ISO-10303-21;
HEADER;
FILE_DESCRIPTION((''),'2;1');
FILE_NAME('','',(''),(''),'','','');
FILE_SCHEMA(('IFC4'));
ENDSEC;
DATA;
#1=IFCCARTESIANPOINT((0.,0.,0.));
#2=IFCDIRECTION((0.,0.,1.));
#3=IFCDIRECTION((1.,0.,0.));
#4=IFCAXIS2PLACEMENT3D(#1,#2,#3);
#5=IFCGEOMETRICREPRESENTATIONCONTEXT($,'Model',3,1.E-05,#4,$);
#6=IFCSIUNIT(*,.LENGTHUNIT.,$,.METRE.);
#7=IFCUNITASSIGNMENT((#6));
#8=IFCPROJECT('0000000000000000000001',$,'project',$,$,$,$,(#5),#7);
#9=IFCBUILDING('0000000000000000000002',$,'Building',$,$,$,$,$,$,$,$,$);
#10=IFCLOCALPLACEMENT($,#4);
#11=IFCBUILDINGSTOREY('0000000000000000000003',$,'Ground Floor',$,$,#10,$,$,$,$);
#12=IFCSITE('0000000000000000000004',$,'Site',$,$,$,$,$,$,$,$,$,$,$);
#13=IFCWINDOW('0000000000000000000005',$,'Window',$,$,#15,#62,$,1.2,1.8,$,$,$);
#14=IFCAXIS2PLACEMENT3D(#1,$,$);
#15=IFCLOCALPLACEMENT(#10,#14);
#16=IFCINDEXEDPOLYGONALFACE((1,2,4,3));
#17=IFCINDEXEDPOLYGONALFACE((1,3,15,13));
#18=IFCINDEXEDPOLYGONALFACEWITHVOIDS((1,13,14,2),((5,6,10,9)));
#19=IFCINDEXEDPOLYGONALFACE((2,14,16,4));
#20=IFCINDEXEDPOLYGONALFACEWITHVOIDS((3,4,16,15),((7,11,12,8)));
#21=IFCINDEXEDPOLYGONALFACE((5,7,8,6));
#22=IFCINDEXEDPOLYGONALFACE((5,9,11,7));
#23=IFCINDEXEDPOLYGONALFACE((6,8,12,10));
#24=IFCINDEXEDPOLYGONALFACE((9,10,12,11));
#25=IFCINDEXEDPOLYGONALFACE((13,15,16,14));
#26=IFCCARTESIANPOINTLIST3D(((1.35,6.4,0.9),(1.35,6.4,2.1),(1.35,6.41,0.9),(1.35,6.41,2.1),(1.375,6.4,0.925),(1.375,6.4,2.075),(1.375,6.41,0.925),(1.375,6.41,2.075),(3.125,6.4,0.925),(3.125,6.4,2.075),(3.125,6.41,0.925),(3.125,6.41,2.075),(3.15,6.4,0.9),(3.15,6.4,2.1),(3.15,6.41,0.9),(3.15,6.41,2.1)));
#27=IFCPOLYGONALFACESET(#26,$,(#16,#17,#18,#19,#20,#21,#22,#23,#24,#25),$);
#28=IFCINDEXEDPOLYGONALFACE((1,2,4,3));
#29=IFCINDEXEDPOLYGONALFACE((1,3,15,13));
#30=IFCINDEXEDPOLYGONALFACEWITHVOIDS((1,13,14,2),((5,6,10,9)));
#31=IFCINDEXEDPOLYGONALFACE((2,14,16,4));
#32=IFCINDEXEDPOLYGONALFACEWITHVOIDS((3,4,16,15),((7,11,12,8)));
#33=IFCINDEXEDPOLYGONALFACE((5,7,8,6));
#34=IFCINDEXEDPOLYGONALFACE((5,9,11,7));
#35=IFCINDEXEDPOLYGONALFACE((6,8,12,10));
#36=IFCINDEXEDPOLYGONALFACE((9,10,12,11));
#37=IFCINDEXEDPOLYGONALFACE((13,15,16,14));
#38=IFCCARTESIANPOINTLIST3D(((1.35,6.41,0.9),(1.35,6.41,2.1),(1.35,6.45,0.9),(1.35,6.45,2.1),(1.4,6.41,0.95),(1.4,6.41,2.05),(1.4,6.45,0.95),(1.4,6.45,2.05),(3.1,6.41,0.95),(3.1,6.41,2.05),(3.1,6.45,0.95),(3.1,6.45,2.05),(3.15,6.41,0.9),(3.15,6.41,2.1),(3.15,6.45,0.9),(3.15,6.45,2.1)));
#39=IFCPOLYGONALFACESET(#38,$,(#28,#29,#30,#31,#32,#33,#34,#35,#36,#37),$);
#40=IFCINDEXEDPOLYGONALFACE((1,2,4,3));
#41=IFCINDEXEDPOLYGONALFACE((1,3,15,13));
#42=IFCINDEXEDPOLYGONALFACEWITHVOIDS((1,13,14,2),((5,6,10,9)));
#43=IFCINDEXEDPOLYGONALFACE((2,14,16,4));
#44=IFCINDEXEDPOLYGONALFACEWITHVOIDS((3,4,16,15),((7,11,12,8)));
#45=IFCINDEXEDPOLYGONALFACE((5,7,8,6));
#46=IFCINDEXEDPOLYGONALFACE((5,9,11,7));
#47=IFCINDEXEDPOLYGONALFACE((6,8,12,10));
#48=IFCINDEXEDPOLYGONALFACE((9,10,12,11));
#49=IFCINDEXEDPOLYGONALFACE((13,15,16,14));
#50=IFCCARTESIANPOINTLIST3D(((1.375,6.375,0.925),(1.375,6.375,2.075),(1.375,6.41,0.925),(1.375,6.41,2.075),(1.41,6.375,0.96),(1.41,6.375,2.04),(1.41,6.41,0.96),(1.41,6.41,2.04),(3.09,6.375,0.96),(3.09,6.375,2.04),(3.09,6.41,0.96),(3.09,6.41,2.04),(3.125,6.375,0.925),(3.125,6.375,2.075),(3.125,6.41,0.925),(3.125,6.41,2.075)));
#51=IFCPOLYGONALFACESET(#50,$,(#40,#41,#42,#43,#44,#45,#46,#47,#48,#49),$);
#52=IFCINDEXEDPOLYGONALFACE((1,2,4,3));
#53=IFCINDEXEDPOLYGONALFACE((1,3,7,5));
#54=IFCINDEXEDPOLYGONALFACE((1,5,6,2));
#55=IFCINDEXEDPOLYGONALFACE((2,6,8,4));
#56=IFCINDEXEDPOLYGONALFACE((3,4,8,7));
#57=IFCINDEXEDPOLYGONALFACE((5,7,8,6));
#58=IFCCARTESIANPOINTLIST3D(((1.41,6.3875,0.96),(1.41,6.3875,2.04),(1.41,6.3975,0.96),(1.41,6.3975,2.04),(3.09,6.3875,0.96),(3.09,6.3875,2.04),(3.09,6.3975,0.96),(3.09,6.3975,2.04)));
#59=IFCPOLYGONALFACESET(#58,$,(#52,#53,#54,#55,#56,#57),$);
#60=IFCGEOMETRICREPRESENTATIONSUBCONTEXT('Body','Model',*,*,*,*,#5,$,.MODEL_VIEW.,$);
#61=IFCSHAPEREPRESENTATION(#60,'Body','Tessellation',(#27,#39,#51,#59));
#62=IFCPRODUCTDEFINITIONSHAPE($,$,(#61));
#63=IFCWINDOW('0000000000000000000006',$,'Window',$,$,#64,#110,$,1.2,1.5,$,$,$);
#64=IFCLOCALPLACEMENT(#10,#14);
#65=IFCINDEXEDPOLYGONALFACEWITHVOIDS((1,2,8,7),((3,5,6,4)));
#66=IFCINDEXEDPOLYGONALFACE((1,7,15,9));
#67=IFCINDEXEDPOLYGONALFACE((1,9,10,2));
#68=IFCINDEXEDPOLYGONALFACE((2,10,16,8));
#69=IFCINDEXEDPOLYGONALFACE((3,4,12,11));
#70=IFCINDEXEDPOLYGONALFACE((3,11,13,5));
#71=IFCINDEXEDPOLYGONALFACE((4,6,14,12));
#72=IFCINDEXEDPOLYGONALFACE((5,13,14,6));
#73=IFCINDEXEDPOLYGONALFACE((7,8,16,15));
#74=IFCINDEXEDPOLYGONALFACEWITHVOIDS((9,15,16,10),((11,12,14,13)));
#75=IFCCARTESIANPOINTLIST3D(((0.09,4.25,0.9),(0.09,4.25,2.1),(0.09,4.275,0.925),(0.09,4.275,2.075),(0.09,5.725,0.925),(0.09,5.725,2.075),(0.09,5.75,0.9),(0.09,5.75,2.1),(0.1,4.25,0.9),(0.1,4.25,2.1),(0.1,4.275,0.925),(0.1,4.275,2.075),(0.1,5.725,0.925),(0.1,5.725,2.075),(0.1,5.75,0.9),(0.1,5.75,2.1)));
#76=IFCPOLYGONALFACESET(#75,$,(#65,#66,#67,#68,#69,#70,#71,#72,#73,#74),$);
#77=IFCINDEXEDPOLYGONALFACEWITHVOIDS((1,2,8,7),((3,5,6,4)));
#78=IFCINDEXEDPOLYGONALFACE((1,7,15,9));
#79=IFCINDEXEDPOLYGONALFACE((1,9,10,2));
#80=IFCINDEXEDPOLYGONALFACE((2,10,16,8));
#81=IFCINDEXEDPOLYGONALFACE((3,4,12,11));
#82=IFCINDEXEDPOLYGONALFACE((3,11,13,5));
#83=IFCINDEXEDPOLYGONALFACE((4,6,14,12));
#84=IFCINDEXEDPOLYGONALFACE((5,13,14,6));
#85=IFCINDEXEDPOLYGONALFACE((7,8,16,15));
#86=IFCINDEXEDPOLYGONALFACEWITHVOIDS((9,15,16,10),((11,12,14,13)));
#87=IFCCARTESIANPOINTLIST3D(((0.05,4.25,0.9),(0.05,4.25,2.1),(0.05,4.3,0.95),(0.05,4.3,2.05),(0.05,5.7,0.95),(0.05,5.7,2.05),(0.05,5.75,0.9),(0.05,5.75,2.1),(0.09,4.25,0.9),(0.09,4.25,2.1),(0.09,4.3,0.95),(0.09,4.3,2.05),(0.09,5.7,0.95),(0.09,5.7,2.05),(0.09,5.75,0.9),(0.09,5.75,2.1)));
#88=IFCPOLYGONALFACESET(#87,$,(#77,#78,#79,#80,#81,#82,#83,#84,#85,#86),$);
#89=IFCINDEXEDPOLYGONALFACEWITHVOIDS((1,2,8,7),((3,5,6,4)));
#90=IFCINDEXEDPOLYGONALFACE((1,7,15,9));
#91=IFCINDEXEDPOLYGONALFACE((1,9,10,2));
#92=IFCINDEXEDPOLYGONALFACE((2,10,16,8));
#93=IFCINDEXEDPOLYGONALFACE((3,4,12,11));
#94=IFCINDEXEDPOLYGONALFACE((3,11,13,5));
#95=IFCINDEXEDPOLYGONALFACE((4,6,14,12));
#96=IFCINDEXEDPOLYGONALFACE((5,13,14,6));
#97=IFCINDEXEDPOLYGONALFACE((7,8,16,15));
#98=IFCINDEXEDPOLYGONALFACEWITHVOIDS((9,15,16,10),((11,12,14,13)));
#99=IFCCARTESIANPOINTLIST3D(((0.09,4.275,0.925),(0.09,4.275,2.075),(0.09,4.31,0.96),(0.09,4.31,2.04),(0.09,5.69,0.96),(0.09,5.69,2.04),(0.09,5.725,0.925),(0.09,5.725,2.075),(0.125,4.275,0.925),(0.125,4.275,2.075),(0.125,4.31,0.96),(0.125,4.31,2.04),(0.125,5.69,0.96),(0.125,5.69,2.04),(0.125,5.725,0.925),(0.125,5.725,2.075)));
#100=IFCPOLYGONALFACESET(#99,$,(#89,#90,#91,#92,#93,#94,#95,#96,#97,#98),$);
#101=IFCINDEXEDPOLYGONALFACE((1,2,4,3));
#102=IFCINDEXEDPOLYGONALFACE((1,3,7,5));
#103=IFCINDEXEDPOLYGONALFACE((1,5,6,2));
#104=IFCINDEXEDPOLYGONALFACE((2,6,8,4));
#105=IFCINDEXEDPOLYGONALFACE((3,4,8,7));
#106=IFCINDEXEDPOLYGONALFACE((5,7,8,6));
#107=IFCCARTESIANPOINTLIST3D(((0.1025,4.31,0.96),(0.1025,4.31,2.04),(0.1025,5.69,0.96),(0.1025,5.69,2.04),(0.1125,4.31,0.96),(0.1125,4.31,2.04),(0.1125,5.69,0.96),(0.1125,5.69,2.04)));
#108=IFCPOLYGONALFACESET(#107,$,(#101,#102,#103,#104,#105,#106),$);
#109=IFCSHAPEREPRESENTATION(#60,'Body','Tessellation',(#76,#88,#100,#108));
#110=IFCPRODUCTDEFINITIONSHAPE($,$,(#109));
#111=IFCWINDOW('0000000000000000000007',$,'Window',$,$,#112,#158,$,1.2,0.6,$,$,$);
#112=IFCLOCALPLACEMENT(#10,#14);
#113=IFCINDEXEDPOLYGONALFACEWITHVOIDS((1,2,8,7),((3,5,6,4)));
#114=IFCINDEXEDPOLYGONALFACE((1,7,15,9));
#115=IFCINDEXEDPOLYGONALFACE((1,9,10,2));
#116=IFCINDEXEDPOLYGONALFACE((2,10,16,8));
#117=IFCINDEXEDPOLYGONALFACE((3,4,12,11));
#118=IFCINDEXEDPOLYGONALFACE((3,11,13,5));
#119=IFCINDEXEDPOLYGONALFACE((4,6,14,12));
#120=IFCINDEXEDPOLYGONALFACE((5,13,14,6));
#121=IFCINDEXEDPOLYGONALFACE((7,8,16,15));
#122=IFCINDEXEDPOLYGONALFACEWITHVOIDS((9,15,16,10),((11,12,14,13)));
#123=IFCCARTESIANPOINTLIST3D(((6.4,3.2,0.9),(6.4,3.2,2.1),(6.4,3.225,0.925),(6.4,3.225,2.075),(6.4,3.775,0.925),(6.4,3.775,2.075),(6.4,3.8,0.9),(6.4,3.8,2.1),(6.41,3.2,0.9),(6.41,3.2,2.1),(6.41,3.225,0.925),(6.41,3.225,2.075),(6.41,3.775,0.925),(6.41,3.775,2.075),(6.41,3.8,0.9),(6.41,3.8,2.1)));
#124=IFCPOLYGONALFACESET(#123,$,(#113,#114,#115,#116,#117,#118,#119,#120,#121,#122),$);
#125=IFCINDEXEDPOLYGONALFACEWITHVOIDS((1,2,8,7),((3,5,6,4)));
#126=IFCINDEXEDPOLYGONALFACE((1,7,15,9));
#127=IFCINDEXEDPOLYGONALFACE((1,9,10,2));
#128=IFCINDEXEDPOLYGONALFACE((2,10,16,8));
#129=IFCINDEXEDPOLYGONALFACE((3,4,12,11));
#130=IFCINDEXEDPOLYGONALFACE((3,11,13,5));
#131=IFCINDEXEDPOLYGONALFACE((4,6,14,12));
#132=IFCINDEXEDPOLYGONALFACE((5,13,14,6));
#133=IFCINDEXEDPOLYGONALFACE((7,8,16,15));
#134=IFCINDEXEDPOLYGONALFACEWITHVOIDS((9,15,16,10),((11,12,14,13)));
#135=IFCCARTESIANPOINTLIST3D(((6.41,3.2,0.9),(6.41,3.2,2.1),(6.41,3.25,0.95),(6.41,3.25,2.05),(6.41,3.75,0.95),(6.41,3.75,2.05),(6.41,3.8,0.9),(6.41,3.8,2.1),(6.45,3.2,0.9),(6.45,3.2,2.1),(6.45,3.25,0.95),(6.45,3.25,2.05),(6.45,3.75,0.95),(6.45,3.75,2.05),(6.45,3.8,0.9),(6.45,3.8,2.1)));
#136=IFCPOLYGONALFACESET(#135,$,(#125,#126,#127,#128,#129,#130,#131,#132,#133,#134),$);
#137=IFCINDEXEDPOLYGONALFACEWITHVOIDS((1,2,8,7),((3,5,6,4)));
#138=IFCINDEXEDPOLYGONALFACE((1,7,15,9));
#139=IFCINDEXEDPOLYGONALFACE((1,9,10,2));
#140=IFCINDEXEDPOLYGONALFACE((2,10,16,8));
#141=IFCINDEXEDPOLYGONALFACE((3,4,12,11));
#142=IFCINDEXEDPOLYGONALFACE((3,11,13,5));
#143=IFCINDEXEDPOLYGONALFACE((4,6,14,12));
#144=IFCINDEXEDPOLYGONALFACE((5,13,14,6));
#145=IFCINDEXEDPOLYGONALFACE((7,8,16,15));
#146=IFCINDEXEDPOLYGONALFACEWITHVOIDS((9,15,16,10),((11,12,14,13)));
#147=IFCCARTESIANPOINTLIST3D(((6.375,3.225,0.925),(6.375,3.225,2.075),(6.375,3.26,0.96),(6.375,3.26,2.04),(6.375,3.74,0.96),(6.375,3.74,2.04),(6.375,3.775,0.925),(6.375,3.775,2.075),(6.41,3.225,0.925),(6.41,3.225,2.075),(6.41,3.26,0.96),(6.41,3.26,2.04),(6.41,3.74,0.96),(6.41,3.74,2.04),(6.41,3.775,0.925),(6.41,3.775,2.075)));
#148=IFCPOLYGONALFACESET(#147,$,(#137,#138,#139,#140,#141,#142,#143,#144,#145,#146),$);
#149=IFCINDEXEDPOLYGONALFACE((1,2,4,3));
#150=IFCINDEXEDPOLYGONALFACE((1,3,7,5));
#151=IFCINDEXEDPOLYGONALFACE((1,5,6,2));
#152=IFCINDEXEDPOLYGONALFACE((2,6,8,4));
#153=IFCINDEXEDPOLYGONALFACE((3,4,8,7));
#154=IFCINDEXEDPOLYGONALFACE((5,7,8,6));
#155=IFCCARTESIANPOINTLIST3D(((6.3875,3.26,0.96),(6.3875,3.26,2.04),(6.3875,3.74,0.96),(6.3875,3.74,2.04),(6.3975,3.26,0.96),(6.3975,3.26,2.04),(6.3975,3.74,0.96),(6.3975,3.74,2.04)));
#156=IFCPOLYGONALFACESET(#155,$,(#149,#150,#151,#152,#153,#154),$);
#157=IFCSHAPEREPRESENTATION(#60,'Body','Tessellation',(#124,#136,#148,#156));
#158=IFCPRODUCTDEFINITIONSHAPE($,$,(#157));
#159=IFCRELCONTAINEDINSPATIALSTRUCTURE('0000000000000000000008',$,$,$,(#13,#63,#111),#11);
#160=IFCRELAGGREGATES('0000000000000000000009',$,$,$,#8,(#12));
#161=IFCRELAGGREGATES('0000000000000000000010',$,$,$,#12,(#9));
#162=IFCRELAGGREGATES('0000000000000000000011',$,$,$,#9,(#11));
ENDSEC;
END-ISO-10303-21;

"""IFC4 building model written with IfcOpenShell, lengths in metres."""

from ifc_helpers import new_model, si_unit, frame, origin_with_axes, place, context, subcontext, project, spatial, line, indexed_curve, outline, extrude, element, save


model = new_model("IFC4")

# Units and contexts
model_context = context("Model", 3, precision=1e-05, world=origin_with_axes())
body_context = subcontext(model_context, "Body", "Model", "MODEL_VIEW")
ifc_project = project(units=[si_unit("LENGTHUNIT", "METRE")], contexts=[model_context])

# Site, building, storey
site = spatial("IfcSite", under=ifc_project, Name="Site")
building = spatial("IfcBuilding", under=site, Name="Building")
storey_placement = place(None, origin_with_axes())
storey = spatial("IfcBuildingStorey", under=building, at=storey_placement, Name="Ground Floor")

# Windows
window_1_placement = place(storey_placement, frame((3.15, 6.5, 0.9), z_axis=(0.0, 0.0, 1.0), x_axis=(-1.0, 0.0, 0.0)))
element("IfcWindow", 1, at=window_1_placement, inside=storey, Name="Window", OverallHeight=1.2, OverallWidth=1.8, context=body_context, shape_type="SweptSolid", body=[
    extrude(outline(indexed_curve([(0.0, 0.0), (1.8, 0.0), (1.8, 1.2), (0.0, 1.2)], segments=[line(1, 2, 3, 4, 1)]), holes=[indexed_curve([(0.025, 0.025), (1.775, 0.025), (1.775, 1.175), (0.025, 1.175)], segments=[line(1, 2, 3, 4, 1)])]), frame((0.0, 0.09, 0.0), z_axis=(0.0, -1.0, 0.0), x_axis=(1.0, 0.0, 0.0)), (0.0, 0.0, -1.0), 0.01),
    extrude(outline(indexed_curve([(0.0, 0.0), (1.8, 0.0), (1.8, 1.2), (0.0, 1.2)], segments=[line(1, 2, 3, 4, 1)]), holes=[indexed_curve([(0.05, 0.05), (1.75, 0.05), (1.75, 1.15), (0.05, 1.15)], segments=[line(1, 2, 3, 4, 1)])]), frame((0.0, 0.05, 0.0), z_axis=(0.0, -1.0, 0.0), x_axis=(1.0, 0.0, 0.0)), (0.0, 0.0, -1.0), 0.04),
    extrude(outline(indexed_curve([(0.0, 0.0), (1.75, 0.0), (1.75, 1.15), (0.0, 1.15)], segments=[line(1, 2, 3, 4, 1)]), holes=[indexed_curve([(0.035, 0.035), (1.715, 0.035), (1.715, 1.115), (0.035, 1.115)], segments=[line(1, 2, 3, 4, 1)])]), frame((0.025, 0.09, 0.025), z_axis=(0.0, -1.0, 0.0), x_axis=(1.0, 0.0, 0.0)), (0.0, 0.0, -1.0), 0.035),
    extrude(outline(indexed_curve([(0.035, 0.035), (1.715, 0.035), (1.715, 1.115), (0.035, 1.115)], segments=[line(1, 2, 3, 4, 1)])), frame((0.025, 0.1025, 0.025), z_axis=(0.0, -1.0, 0.0), x_axis=(1.0, 0.0, 0.0)), (0.0, 0.0, -1.0), 0.01),
])
window_2_placement = place(storey_placement, frame((0.0, 5.75, 0.9), z_axis=(0.0, 0.0, 1.0), x_axis=(0.0, -1.0, 0.0)))
element("IfcWindow", 2, at=window_2_placement, inside=storey, Name="Window", OverallHeight=1.2, OverallWidth=1.5, context=body_context, shape_type="SweptSolid", body=[
    extrude(outline(indexed_curve([(0.0, 0.0), (1.5, 0.0), (1.5, 1.2), (0.0, 1.2)], segments=[line(1, 2, 3, 4, 1)]), holes=[indexed_curve([(0.025, 0.025), (1.475, 0.025), (1.475, 1.175), (0.025, 1.175)], segments=[line(1, 2, 3, 4, 1)])]), frame((0.0, 0.09, 0.0), z_axis=(0.0, -1.0, 0.0), x_axis=(1.0, 0.0, 0.0)), (0.0, 0.0, -1.0), 0.01),
    extrude(outline(indexed_curve([(0.0, 0.0), (1.5, 0.0), (1.5, 1.2), (0.0, 1.2)], segments=[line(1, 2, 3, 4, 1)]), holes=[indexed_curve([(0.05, 0.05), (1.45, 0.05), (1.45, 1.15), (0.05, 1.15)], segments=[line(1, 2, 3, 4, 1)])]), frame((0.0, 0.05, 0.0), z_axis=(0.0, -1.0, 0.0), x_axis=(1.0, 0.0, 0.0)), (0.0, 0.0, -1.0), 0.04),
    extrude(outline(indexed_curve([(0.0, 0.0), (1.45, 0.0), (1.45, 1.15), (0.0, 1.15)], segments=[line(1, 2, 3, 4, 1)]), holes=[indexed_curve([(0.035, 0.035), (1.415, 0.035), (1.415, 1.115), (0.035, 1.115)], segments=[line(1, 2, 3, 4, 1)])]), frame((0.025, 0.09, 0.025), z_axis=(0.0, -1.0, 0.0), x_axis=(1.0, 0.0, 0.0)), (0.0, 0.0, -1.0), 0.035),
    extrude(outline(indexed_curve([(0.035, 0.035), (1.415, 0.035), (1.415, 1.115), (0.035, 1.115)], segments=[line(1, 2, 3, 4, 1)])), frame((0.025, 0.1025, 0.025), z_axis=(0.0, -1.0, 0.0), x_axis=(1.0, 0.0, 0.0)), (0.0, 0.0, -1.0), 0.01),
])
window_3_placement = place(storey_placement, frame((6.5, 3.2, 0.9), z_axis=(0.0, 0.0, 1.0), x_axis=(0.0, 1.0, 0.0)))
element("IfcWindow", 3, at=window_3_placement, inside=storey, Name="Window", OverallHeight=1.2, OverallWidth=0.6, context=body_context, shape_type="SweptSolid", body=[
    extrude(outline(indexed_curve([(0.0, 0.0), (0.6, 0.0), (0.6, 1.2), (0.0, 1.2)], segments=[line(1, 2, 3, 4, 1)]), holes=[indexed_curve([(0.025, 0.025), (0.575, 0.025), (0.575, 1.175), (0.025, 1.175)], segments=[line(1, 2, 3, 4, 1)])]), frame((0.0, 0.09, 0.0), z_axis=(0.0, -1.0, 0.0), x_axis=(1.0, 0.0, 0.0)), (0.0, 0.0, -1.0), 0.01),
    extrude(outline(indexed_curve([(0.0, 0.0), (0.6, 0.0), (0.6, 1.2), (0.0, 1.2)], segments=[line(1, 2, 3, 4, 1)]), holes=[indexed_curve([(0.05, 0.05), (0.55, 0.05), (0.55, 1.15), (0.05, 1.15)], segments=[line(1, 2, 3, 4, 1)])]), frame((0.0, 0.05, 0.0), z_axis=(0.0, -1.0, 0.0), x_axis=(1.0, 0.0, 0.0)), (0.0, 0.0, -1.0), 0.04),
    extrude(outline(indexed_curve([(0.0, 0.0), (0.55, 0.0), (0.55, 1.15), (0.0, 1.15)], segments=[line(1, 2, 3, 4, 1)]), holes=[indexed_curve([(0.035, 0.035), (0.515, 0.035), (0.515, 1.115), (0.035, 1.115)], segments=[line(1, 2, 3, 4, 1)])]), frame((0.025, 0.09, 0.025), z_axis=(0.0, -1.0, 0.0), x_axis=(1.0, 0.0, 0.0)), (0.0, 0.0, -1.0), 0.035),
    extrude(outline(indexed_curve([(0.035, 0.035), (0.515, 0.035), (0.515, 1.115), (0.035, 1.115)], segments=[line(1, 2, 3, 4, 1)])), frame((0.025, 0.1025, 0.025), z_axis=(0.0, -1.0, 0.0), x_axis=(1.0, 0.0, 0.0)), (0.0, 0.0, -1.0), 0.01),
])

save(model, "model.ifc")
